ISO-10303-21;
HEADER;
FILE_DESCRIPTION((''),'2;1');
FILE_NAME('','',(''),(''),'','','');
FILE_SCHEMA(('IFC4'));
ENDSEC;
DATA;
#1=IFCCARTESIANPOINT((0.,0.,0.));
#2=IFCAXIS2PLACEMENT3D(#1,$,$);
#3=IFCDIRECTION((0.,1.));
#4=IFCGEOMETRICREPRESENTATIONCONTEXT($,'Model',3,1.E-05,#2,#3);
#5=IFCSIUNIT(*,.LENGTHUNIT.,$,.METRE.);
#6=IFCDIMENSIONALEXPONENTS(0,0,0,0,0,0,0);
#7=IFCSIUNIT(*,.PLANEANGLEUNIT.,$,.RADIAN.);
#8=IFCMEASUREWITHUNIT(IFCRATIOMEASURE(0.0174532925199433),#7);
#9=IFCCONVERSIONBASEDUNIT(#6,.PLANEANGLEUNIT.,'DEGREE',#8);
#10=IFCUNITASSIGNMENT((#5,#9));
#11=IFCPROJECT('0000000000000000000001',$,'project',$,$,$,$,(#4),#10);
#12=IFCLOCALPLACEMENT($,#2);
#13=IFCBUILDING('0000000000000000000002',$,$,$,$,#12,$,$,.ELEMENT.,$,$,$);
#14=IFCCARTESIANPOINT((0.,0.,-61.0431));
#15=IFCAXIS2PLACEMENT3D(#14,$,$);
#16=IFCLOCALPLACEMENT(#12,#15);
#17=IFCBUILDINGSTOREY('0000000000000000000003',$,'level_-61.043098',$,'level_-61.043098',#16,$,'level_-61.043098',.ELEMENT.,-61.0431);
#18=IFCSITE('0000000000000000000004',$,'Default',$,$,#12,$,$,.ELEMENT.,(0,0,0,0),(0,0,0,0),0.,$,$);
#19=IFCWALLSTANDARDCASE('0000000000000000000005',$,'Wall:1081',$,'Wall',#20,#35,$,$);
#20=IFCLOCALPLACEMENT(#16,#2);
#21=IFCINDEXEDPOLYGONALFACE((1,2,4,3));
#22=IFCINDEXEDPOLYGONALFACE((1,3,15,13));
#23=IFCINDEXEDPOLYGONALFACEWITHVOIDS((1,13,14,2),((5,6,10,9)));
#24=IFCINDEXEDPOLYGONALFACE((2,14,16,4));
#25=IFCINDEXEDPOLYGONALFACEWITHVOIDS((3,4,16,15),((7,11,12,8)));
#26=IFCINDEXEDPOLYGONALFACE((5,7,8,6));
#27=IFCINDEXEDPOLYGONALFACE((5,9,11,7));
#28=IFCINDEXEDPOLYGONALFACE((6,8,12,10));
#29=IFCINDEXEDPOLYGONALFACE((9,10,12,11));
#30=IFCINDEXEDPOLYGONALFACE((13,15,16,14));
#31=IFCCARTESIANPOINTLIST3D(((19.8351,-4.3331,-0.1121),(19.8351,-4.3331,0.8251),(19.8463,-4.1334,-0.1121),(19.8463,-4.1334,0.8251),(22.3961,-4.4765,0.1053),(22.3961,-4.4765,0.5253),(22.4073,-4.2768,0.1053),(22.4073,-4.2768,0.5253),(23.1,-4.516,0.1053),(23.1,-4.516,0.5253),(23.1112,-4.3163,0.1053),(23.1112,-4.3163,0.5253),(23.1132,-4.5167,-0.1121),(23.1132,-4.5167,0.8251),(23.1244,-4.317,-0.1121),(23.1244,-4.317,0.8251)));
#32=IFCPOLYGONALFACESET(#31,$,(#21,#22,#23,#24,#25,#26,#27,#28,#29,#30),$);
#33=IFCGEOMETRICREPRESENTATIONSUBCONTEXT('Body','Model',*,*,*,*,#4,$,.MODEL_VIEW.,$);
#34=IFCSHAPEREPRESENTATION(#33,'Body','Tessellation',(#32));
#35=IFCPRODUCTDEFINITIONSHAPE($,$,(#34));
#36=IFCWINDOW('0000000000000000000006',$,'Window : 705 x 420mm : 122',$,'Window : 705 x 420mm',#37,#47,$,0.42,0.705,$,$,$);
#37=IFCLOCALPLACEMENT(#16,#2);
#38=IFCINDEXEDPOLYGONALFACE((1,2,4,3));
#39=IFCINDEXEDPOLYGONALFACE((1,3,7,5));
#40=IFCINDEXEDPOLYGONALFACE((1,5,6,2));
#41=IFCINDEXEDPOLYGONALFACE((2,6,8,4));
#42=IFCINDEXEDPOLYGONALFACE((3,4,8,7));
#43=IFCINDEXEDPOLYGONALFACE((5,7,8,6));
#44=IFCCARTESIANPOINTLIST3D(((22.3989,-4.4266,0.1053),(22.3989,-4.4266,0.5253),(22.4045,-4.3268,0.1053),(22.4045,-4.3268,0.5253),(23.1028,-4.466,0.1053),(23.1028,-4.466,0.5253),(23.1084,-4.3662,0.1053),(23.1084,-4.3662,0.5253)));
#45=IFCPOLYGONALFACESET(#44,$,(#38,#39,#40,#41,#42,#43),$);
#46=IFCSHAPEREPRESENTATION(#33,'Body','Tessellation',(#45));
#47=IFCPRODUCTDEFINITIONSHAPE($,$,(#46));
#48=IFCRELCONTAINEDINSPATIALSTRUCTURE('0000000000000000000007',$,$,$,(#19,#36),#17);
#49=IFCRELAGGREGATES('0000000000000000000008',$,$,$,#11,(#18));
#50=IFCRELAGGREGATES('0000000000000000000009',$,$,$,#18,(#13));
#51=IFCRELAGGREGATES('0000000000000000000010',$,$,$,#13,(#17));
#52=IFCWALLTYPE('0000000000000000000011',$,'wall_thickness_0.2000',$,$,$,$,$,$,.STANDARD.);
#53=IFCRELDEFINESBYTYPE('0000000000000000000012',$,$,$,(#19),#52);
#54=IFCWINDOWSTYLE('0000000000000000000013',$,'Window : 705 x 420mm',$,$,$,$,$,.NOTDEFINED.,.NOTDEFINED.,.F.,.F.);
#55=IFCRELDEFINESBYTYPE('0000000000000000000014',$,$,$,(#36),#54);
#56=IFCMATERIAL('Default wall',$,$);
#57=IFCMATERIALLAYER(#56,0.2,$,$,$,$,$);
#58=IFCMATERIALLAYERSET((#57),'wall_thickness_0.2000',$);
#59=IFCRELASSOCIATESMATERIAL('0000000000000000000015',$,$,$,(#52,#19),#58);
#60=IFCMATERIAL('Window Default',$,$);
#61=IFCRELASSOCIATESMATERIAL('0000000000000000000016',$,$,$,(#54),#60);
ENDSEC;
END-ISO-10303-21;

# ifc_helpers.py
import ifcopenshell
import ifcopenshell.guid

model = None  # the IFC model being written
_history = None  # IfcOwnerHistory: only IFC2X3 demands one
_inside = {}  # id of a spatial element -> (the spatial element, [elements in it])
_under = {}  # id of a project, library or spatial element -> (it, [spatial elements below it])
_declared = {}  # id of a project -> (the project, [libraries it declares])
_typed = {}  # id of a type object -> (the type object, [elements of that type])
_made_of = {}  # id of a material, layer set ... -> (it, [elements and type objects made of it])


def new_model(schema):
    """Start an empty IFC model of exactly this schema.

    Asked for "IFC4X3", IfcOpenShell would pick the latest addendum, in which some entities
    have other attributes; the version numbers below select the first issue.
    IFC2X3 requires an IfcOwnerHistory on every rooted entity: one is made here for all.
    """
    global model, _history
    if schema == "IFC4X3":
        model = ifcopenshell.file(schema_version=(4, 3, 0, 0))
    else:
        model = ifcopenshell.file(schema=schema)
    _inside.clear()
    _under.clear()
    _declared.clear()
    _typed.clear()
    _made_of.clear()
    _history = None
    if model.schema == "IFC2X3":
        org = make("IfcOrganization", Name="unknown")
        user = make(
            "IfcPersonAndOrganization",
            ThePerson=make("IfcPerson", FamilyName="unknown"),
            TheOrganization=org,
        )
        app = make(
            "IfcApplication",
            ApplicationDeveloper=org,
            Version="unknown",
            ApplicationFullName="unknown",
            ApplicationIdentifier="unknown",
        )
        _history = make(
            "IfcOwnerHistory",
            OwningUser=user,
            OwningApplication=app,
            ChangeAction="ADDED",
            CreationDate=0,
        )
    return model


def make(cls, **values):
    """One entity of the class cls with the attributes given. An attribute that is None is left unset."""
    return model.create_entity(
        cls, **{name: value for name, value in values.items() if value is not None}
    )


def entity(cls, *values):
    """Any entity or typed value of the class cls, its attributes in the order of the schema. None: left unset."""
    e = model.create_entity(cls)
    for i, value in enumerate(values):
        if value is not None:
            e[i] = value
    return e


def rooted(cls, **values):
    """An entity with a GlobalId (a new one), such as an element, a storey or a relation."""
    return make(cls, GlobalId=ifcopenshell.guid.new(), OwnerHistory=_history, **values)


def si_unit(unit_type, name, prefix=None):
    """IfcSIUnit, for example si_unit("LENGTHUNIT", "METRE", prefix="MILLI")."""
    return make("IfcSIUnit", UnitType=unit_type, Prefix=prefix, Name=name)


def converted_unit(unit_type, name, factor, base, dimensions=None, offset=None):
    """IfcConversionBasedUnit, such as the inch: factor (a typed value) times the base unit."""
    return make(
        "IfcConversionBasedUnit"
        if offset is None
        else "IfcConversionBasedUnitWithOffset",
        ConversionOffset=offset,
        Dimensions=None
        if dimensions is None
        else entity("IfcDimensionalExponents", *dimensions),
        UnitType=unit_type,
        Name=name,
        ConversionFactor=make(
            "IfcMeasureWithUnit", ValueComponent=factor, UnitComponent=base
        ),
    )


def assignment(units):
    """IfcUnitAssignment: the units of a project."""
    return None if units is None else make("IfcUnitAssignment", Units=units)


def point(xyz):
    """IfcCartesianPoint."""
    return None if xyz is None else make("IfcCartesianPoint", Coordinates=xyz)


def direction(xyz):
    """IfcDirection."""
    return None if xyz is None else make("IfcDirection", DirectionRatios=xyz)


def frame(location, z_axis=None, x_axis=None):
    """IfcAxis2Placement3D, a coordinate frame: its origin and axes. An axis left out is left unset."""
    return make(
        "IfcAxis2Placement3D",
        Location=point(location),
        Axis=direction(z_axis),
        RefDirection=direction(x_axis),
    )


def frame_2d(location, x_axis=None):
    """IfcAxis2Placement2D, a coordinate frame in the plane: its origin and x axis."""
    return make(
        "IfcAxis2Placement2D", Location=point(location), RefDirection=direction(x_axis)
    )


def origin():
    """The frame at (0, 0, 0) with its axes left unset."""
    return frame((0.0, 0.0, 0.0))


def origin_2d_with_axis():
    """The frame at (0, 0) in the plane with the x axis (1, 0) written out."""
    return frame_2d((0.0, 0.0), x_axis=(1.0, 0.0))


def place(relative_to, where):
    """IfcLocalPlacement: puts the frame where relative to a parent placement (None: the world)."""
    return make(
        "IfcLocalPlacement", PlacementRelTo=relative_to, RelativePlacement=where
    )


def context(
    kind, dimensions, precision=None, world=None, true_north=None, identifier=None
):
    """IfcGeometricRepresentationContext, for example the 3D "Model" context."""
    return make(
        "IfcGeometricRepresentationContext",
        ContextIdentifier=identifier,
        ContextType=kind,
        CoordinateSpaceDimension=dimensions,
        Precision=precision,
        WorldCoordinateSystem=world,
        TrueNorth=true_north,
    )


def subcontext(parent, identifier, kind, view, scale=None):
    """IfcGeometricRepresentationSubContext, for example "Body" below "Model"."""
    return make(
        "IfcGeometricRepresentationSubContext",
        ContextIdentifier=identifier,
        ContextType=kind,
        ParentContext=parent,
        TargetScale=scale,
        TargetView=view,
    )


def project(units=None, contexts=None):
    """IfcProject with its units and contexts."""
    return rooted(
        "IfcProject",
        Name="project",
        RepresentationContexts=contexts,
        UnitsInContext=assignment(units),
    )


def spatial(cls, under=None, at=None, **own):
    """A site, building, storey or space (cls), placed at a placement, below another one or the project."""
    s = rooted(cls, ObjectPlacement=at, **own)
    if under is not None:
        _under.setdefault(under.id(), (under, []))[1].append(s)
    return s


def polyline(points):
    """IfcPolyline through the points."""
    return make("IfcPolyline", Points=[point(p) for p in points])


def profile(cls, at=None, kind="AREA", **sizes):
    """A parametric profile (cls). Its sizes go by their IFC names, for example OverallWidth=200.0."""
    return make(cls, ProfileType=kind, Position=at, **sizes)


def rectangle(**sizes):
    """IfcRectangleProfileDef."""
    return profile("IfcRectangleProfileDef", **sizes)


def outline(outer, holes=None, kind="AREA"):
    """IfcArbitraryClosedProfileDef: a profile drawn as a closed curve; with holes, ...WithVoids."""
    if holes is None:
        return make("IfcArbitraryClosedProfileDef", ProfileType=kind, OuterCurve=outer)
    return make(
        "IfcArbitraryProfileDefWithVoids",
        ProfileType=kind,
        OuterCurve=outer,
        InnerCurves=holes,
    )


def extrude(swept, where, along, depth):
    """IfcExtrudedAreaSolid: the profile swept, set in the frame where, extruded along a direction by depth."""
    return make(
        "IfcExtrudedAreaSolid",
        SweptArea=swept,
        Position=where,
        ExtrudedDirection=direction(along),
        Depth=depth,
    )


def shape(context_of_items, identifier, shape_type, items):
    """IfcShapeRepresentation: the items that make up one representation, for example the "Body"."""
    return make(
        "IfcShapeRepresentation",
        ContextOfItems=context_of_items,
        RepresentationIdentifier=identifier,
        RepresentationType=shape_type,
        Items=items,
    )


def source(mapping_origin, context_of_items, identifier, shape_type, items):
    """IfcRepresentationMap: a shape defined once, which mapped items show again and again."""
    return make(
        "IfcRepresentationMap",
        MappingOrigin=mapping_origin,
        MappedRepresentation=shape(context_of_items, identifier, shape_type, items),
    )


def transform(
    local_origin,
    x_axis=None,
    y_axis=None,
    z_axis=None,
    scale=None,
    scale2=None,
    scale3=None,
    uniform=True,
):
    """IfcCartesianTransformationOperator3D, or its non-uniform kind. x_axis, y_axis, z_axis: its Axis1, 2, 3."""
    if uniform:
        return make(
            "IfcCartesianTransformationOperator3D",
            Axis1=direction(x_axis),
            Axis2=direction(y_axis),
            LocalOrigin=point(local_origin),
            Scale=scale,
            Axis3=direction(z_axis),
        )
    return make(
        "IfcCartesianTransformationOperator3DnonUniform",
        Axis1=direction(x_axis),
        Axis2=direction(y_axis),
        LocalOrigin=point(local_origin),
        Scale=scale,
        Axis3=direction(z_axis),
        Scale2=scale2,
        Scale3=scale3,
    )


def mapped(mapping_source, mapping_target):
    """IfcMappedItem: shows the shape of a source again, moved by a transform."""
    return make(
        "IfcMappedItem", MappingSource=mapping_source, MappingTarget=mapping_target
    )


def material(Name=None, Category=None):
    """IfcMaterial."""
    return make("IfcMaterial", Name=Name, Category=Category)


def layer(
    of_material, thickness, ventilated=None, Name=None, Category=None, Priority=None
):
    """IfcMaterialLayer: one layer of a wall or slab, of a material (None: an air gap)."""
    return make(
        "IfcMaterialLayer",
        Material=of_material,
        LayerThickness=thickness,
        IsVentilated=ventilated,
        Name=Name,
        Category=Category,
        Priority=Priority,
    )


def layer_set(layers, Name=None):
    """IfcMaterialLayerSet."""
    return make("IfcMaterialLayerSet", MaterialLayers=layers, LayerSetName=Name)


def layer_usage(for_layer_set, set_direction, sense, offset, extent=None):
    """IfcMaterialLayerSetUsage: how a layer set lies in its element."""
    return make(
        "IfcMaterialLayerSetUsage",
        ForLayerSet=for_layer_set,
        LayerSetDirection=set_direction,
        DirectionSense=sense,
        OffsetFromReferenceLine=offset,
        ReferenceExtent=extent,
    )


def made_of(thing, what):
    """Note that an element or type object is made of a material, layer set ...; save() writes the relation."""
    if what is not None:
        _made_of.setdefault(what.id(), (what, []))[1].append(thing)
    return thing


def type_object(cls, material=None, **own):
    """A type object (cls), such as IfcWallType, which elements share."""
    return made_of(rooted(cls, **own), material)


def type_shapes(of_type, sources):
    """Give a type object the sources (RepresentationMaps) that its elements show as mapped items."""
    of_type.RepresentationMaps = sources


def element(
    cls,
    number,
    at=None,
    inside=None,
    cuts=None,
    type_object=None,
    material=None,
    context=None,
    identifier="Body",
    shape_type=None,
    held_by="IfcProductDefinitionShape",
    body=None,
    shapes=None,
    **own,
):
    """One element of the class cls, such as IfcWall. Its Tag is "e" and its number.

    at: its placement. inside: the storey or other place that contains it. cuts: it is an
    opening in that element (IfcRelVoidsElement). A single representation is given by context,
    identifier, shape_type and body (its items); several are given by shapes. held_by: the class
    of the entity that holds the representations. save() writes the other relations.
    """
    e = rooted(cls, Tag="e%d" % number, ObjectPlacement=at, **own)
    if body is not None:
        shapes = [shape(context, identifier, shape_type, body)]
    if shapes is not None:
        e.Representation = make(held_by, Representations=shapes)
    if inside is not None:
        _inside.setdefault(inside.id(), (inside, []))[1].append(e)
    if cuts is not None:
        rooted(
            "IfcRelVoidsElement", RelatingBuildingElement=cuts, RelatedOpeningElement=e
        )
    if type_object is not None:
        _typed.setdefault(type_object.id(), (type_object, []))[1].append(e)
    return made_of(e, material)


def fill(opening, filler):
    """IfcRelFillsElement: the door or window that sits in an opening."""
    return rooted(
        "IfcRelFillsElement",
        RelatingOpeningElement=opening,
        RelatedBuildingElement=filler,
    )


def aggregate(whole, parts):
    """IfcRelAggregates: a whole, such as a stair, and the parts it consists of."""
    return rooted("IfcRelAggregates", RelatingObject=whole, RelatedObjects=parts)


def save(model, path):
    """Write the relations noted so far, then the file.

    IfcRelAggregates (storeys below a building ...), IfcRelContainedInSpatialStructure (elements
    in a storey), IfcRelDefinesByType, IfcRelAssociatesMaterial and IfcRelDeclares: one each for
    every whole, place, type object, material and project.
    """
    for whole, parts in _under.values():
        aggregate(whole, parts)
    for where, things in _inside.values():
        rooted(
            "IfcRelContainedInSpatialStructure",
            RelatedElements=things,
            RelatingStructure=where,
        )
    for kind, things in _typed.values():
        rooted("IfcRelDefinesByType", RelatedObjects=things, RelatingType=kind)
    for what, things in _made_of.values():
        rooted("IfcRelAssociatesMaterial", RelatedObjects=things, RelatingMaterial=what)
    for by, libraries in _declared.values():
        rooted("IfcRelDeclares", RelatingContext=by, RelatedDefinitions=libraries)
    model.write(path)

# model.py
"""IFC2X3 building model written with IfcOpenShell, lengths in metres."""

from ifc_helpers import new_model, entity, si_unit, converted_unit, direction, frame, frame_2d, origin, origin_2d_with_axis, place, context, subcontext, project, spatial, polyline, rectangle, outline, extrude, source, transform, mapped, material, layer, layer_set, layer_usage, type_object, type_shapes, element, fill, save


model = new_model("IFC2X3")

# Units and contexts
model_context = context("Model", 3, precision=1e-05, world=origin(), true_north=direction((0.0, 1.0)))
body_context = subcontext(model_context, "Body", "Model", "MODEL_VIEW")
ifc_project = project(units=[si_unit("LENGTHUNIT", "METRE"), converted_unit("PLANEANGLEUNIT", "DEGREE", entity("IfcRatioMeasure", 0.0174532925199433), si_unit("PLANEANGLEUNIT", "RADIAN"), dimensions=[0, 0, 0, 0, 0, 0, 0])], contexts=[model_context])

# Site, building, storey
placement_1 = place(None, origin())
site = spatial("IfcSite", under=ifc_project, at=placement_1, Name="Default", CompositionType="ELEMENT", RefLatitude=(0, 0, 0, 0), RefLongitude=(0, 0, 0, 0), RefElevation=0.0)
building = spatial("IfcBuilding", under=site, at=placement_1, CompositionType="ELEMENT")
storey_placement = place(placement_1, frame((0.0, 0.0, -61.0431)))
storey = spatial("IfcBuildingStorey", under=building, at=storey_placement, Name="level_-61.043098", ObjectType="level_-61.043098", LongName="level_-61.043098", CompositionType="ELEMENT", Elevation=-61.0431)

# Shared definitions
ifc_material_1 = material(Name="Default wall")
ifc_layer = layer(ifc_material_1, 0.2)
ifc_layer_set = layer_set([ifc_layer], Name="wall_thickness_0.2000")
ifc_layer_usage = layer_usage(ifc_layer_set, "AXIS2", "POSITIVE", -0.1)
wall_type = type_object("IfcWallType", Name="wall_thickness_0.2000", PredefinedType="STANDARD", material=ifc_layer_set)
ifc_material_2 = material(Name="Window Default")

# Wall, opening, window
placement_2 = place(placement_1, frame((0.0, 0.0, -61.1552)))
wall_1_placement = place(placement_2, frame((19.8407, -4.2332, 0.0), z_axis=(0.0, 0.0, 1.0), x_axis=(0.998435, -0.055929, 0.0)))
wall_1 = element("IfcWallStandardCase", 1, at=wall_1_placement, inside=storey, type_object=wall_type, material=ifc_layer_usage, Name="Wall:1081", ObjectType="Wall", context=body_context, shape_type="SweptSolid", body=[
    extrude(outline(polyline([(3.2832, -0.1), (3.2832, 0.1), (0.0, 0.1), (0.0, -0.1), (3.2832, -0.1)])), origin(), (0.0, 0.0, 1.0), 0.9372),
])
opening_1_placement = place(wall_1_placement, frame((2.565, -0.1, 0.2174)))
opening_1 = element("IfcOpeningElement", 2, at=opening_1_placement, cuts=wall_1, ObjectType="Opening", context=body_context, shape_type="SweptSolid", body=[
    extrude(rectangle(XDim=0.705, YDim=0.42, at=frame_2d((0.21, 0.3525), x_axis=(0.0, 1.0))), frame((0.0, 0.0, 0.0), z_axis=(0.0, 1.0, 0.0), x_axis=(0.0, 0.0, 1.0)), (0.0, 0.0, 1.0), 0.2),
])
window_style_1 = type_object("IfcWindowStyle", Name="Window : 705 x 420mm", ConstructionType="NOTDEFINED", OperationType="NOTDEFINED", ParameterTakesPrecedence=False, Sizeable=False, material=ifc_material_2)
shared_shape_1 = source(origin(), body_context, "Body", "SweptSolid", [
    extrude(rectangle(XDim=0.1, YDim=0.705, at=origin_2d_with_axis()), frame((0.3525, 0.1, 0.0), z_axis=(0.0, 0.0, 1.0), x_axis=(0.0, 1.0, 0.0)), (0.0, 0.0, 1.0), 0.42),
])
type_shapes(window_style_1, [shared_shape_1])
window_1_placement = place(opening_1_placement, origin())
window_1 = element("IfcWindow", 3, at=window_1_placement, inside=storey, type_object=window_style_1, Name="Window : 705 x 420mm : 122", ObjectType="Window : 705 x 420mm", OverallHeight=0.42, OverallWidth=0.705, context=body_context, shape_type="MappedRepresentation", body=[
    mapped(shared_shape_1, transform((0.0, 0.0, 0.0), scale=1.0)),
])
fill(opening_1, window_1)

save(model, "model.ifc")
